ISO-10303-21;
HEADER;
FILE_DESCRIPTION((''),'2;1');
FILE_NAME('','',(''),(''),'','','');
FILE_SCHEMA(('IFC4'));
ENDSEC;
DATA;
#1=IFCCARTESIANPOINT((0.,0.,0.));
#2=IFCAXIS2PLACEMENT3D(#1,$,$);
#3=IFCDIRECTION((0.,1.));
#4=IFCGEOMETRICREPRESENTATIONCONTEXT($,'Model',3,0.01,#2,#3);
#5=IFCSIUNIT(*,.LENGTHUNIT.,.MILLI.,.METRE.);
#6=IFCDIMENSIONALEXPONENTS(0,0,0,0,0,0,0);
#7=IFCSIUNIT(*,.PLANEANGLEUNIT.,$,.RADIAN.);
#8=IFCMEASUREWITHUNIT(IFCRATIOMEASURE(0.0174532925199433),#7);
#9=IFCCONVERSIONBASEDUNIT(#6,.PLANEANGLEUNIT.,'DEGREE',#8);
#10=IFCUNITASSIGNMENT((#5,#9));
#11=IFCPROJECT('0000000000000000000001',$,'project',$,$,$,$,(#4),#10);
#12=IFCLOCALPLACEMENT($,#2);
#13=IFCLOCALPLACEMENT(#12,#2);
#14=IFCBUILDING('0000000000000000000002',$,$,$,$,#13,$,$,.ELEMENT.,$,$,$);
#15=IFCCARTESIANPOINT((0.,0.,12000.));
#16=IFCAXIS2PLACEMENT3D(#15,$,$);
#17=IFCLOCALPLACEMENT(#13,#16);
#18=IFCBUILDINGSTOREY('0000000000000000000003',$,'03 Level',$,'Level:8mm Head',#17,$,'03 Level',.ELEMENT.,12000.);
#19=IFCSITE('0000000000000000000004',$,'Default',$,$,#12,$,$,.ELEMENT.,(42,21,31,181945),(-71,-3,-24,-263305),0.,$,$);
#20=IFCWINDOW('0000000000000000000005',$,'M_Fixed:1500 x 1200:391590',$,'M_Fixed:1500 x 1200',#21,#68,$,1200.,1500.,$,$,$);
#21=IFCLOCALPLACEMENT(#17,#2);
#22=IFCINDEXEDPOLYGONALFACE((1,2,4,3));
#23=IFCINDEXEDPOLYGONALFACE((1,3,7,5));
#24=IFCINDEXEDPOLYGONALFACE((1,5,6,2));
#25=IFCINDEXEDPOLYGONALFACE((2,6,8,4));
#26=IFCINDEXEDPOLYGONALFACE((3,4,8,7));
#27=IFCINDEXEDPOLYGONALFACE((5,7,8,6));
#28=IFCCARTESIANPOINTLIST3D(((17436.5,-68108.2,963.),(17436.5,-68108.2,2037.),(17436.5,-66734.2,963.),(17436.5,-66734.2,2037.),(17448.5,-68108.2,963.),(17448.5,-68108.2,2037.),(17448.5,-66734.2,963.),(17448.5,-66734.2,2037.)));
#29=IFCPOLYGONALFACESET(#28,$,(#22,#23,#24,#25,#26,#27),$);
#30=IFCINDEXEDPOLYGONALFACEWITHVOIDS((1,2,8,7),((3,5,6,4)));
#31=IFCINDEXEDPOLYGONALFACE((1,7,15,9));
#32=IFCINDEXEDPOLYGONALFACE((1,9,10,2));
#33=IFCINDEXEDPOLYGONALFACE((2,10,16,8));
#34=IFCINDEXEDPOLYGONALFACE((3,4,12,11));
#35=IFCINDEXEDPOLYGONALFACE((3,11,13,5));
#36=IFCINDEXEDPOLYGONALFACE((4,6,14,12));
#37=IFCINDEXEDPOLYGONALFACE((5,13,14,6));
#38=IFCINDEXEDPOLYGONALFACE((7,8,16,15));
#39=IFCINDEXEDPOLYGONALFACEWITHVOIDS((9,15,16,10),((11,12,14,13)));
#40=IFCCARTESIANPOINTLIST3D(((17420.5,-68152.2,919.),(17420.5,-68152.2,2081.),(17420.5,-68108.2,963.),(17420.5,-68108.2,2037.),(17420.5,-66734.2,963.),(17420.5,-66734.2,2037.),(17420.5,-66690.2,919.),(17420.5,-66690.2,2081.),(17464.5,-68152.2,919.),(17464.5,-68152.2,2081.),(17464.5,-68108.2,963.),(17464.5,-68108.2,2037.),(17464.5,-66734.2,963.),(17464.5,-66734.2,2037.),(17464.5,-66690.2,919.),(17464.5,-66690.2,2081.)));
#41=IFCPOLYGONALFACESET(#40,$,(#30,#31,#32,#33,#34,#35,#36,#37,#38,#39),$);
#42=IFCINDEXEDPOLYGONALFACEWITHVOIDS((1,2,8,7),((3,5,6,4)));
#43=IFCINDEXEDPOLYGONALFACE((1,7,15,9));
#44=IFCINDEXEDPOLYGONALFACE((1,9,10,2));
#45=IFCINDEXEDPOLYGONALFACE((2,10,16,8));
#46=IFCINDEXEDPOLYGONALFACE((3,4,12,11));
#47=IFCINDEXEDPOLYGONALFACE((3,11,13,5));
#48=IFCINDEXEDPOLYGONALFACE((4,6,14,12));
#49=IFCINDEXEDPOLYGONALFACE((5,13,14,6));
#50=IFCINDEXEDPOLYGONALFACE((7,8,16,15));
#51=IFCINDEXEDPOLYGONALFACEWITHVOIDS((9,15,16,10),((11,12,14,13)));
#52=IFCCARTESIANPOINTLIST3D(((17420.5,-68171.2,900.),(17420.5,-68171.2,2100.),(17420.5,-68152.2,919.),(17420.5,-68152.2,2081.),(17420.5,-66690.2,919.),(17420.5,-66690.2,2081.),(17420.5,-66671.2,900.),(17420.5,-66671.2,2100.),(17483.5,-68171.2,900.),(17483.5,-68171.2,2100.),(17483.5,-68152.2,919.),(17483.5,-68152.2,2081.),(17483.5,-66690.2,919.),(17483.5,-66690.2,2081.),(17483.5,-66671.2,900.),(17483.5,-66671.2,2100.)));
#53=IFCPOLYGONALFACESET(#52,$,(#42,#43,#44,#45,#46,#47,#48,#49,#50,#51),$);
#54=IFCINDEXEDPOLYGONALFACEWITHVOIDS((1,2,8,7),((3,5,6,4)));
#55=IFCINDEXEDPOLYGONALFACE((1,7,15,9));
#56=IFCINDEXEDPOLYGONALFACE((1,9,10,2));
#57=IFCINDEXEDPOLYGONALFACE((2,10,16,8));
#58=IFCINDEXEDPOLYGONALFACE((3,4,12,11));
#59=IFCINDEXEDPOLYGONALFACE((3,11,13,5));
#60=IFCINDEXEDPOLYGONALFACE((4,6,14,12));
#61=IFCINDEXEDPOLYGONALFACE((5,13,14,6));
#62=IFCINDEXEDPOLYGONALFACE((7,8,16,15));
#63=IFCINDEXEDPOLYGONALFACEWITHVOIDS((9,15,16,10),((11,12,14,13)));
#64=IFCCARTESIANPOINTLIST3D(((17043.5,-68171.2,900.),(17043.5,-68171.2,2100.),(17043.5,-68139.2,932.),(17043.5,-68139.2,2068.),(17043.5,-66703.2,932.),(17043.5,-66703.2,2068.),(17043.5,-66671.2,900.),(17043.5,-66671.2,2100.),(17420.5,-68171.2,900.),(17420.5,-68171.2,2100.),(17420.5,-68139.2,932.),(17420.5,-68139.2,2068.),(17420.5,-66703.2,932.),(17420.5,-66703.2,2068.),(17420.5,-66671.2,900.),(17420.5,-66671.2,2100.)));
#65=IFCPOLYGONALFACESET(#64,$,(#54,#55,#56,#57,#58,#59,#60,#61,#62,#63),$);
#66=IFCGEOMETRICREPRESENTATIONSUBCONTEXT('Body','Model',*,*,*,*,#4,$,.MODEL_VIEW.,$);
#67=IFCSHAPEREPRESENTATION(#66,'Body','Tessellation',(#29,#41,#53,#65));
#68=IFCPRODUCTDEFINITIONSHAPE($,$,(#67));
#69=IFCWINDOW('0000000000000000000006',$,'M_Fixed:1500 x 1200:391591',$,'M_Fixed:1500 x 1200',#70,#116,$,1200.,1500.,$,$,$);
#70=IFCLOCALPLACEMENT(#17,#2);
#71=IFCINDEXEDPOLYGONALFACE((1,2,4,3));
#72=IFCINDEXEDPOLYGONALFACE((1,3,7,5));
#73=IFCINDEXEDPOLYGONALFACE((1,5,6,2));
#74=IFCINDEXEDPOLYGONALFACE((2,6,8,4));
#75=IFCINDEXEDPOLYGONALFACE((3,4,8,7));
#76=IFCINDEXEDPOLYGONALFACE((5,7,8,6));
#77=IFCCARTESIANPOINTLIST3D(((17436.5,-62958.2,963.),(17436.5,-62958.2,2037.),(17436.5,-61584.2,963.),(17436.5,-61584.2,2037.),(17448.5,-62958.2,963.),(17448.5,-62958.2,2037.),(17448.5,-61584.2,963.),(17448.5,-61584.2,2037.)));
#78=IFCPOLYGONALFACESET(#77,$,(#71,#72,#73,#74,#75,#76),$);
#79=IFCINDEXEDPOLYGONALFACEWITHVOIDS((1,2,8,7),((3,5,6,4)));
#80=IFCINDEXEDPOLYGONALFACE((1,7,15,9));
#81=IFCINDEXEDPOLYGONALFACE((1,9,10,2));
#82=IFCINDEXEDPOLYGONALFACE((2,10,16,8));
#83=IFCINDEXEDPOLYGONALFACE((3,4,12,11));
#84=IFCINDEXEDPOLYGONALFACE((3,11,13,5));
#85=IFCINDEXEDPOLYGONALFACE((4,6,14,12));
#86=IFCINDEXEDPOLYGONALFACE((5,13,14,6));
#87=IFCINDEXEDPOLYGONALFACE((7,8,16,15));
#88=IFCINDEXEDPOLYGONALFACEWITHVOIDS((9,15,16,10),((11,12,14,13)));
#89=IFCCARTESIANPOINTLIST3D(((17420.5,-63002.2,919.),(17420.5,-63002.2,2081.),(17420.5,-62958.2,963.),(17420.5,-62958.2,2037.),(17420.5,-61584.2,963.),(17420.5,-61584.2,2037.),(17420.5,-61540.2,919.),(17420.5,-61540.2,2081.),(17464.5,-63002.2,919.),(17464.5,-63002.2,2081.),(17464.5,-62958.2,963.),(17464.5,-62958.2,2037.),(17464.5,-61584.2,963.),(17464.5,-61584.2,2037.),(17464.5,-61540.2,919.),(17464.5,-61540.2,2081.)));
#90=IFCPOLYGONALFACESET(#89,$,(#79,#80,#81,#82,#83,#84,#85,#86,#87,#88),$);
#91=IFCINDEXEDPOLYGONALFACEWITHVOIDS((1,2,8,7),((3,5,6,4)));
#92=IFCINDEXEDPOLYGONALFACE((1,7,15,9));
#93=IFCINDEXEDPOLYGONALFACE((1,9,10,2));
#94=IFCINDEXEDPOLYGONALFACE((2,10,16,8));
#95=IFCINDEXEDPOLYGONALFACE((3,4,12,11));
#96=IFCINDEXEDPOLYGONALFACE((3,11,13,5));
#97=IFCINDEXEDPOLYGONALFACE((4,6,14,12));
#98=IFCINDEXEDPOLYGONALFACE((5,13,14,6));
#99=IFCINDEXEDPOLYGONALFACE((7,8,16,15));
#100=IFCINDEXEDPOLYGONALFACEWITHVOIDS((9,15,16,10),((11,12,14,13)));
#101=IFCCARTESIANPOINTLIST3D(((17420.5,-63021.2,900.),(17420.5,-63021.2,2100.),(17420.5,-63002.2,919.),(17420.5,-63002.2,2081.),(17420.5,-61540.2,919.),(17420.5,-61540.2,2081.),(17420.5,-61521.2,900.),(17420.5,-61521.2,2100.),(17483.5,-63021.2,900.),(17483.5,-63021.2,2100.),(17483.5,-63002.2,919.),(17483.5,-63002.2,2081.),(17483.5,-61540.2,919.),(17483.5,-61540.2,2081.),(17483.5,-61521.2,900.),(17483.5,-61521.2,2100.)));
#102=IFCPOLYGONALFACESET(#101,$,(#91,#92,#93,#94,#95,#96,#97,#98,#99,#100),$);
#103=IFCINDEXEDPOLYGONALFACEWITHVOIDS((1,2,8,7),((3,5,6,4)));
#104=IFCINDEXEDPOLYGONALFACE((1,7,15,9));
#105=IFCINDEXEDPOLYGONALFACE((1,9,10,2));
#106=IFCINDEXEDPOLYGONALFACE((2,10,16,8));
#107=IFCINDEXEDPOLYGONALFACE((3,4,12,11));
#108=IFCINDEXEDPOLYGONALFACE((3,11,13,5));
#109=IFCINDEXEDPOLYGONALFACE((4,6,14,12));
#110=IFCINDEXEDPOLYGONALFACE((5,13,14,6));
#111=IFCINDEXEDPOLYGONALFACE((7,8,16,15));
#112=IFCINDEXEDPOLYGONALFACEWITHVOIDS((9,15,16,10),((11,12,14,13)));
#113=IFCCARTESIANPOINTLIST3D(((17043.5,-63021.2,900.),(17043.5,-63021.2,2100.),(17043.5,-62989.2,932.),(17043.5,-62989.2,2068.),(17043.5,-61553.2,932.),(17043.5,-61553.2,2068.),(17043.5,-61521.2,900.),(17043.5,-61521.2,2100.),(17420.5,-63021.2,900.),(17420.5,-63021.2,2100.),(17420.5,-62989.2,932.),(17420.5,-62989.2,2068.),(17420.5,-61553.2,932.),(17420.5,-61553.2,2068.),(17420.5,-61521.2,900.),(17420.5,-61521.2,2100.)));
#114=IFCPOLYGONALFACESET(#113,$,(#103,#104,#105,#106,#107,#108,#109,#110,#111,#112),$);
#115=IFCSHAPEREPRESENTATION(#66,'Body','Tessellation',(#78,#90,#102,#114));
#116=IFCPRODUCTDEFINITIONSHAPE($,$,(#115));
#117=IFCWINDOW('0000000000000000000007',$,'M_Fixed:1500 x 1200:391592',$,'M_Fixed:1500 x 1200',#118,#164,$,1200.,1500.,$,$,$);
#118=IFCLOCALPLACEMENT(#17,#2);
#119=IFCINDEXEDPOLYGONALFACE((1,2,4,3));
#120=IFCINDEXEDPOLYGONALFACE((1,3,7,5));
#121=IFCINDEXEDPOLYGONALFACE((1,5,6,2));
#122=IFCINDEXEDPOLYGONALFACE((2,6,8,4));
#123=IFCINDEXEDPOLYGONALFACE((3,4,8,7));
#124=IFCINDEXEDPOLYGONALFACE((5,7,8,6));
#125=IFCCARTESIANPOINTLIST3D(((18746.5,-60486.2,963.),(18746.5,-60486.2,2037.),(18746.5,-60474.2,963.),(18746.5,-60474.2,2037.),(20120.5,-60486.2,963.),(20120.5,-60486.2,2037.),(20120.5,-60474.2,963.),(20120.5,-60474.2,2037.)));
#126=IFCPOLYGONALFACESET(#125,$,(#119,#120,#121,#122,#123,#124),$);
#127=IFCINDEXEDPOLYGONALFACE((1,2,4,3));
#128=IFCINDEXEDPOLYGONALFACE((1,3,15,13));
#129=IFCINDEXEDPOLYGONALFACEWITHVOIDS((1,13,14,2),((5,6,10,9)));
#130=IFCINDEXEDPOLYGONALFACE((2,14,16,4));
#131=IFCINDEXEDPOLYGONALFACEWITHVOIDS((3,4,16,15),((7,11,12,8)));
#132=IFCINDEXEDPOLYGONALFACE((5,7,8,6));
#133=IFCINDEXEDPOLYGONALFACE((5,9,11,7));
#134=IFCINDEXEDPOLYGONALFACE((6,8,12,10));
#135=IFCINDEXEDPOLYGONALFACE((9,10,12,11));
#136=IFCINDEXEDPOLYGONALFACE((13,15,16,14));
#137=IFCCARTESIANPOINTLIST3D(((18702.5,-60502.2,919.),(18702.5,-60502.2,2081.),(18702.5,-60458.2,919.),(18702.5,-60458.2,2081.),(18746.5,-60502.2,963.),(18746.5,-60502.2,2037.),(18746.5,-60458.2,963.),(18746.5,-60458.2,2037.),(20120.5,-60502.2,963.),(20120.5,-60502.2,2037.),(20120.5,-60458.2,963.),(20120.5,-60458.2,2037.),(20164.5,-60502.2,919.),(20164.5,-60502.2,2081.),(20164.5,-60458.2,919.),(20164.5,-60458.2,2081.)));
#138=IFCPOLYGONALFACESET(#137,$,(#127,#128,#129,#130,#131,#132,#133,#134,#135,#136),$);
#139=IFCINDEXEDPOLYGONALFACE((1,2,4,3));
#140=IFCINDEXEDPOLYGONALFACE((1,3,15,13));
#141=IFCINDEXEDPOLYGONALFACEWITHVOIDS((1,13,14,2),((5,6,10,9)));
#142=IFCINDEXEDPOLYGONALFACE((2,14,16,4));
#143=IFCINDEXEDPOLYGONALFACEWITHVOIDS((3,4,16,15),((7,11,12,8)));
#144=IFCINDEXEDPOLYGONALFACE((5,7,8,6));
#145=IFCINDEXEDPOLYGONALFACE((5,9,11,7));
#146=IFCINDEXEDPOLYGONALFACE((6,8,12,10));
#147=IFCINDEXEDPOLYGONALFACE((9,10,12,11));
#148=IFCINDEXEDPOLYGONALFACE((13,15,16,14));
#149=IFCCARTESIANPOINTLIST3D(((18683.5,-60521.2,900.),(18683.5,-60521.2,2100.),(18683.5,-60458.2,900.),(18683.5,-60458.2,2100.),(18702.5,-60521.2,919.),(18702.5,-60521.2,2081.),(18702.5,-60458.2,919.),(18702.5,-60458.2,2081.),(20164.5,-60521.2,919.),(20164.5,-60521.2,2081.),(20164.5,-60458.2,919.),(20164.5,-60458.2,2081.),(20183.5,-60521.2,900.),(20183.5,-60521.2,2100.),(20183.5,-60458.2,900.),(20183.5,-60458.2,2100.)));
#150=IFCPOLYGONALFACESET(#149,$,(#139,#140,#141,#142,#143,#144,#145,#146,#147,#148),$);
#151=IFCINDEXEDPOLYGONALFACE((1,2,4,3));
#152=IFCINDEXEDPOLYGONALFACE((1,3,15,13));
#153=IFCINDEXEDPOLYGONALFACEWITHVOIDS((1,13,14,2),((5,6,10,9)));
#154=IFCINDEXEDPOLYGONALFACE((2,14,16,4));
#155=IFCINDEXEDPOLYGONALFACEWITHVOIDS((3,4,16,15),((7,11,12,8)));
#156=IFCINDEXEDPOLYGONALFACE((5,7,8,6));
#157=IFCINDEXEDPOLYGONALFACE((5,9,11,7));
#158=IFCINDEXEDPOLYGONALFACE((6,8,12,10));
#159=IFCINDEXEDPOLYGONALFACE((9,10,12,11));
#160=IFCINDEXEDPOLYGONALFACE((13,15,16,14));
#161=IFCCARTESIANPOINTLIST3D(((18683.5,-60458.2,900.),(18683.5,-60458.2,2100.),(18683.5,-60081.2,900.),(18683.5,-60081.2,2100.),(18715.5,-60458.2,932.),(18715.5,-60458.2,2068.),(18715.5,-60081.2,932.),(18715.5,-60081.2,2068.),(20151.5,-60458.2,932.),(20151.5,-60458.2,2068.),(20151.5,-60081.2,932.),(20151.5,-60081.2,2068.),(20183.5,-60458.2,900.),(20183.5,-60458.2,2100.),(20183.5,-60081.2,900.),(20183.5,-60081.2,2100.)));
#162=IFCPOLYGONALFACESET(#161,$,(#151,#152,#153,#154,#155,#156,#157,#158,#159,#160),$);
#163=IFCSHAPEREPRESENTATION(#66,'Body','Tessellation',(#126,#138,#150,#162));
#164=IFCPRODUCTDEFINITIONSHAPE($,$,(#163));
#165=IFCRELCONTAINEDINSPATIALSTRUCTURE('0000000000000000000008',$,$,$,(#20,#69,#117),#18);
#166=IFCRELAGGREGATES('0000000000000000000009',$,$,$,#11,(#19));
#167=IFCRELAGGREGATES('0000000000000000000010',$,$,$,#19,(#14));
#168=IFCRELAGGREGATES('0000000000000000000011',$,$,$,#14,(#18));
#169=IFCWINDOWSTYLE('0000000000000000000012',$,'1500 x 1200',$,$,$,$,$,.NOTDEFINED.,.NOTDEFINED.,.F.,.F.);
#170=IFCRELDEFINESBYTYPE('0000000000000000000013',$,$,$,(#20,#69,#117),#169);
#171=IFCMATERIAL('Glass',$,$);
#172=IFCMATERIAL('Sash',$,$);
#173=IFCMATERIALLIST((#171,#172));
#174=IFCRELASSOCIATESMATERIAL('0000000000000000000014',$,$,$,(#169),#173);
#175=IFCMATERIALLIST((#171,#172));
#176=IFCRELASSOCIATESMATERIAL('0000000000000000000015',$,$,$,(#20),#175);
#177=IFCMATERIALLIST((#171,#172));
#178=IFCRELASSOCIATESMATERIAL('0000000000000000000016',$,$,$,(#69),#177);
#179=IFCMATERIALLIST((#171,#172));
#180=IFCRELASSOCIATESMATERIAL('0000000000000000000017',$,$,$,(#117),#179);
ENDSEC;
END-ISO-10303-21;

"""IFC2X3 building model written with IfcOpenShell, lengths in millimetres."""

from ifc_helpers import new_model, entity, si_unit, converted_unit, direction, frame, origin, origin_2d_with_axis, place, context, subcontext, project, spatial, polyline, rectangle, outline, extrude, source, transform, mapped, material, material_list, type_object, type_shapes, element, save


model = new_model("IFC2X3")

# Units and contexts
model_context = context("Model", 3, precision=0.01, world=origin(), true_north=direction((0.0, 1.0)))
body_context = subcontext(model_context, "Body", "Model", "MODEL_VIEW")
ifc_project = project(units=[si_unit("LENGTHUNIT", "METRE", prefix="MILLI"), converted_unit("PLANEANGLEUNIT", "DEGREE", entity("IfcRatioMeasure", 0.0174532925199433), si_unit("PLANEANGLEUNIT", "RADIAN"), dimensions=[0, 0, 0, 0, 0, 0, 0])], contexts=[model_context])

# Site, building, storey
site_placement = place(None, origin())
site = spatial("IfcSite", under=ifc_project, at=site_placement, Name="Default", CompositionType="ELEMENT", RefLatitude=(42, 21, 31, 181945), RefLongitude=(-71, -3, -24, -263305), RefElevation=0.0)
building_placement = place(site_placement, origin())
building = spatial("IfcBuilding", under=site, at=building_placement, CompositionType="ELEMENT")
storey_placement = place(building_placement, frame((0.0, 0.0, 12000.0)))
storey = spatial("IfcBuildingStorey", under=building, at=storey_placement, Name="03 Level", ObjectType="Level:8mm Head", LongName="03 Level", CompositionType="ELEMENT", Elevation=12000.0)

# Windows
ifc_material_1 = material(Name="Glass")
ifc_material_2 = material(Name="Sash")
ifc_material_list_1 = material_list([ifc_material_1, ifc_material_2])
ifc_material_list_2 = material_list([ifc_material_1, ifc_material_2])
window_style_1 = type_object("IfcWindowStyle", Name="1500 x 1200", ConstructionType="NOTDEFINED", OperationType="NOTDEFINED", ParameterTakesPrecedence=False, Sizeable=False, material=ifc_material_list_2)
shared_shape_1 = source(origin(), body_context, "Body", "SweptSolid", [
    extrude(rectangle(XDim=1374.0, YDim=12.0, at=origin_2d_with_axis()), frame((750.0, 425.0, 63.0), z_axis=(0.0, 0.0, 1.0), x_axis=(-1.0, 0.0, 0.0)), (0.0, 0.0, 1.0), 1074.0),
    extrude(outline(polyline([(-731.0, -581.0), (731.0, -581.0), (731.0, 581.0), (-731.0, 581.0), (-731.0, -581.0)]), holes=[polyline([(-687.0, -537.0), (-687.0, 537.0), (687.0, 537.0), (687.0, -537.0), (-687.0, -537.0)])]), frame((750.0, 447.0, 600.0), z_axis=(0.0, -1.0, 0.0), x_axis=(-1.0, 0.0, 0.0)), (0.0, 0.0, 1.0), 44.0),
    extrude(outline(polyline([(-750.0, -600.0), (750.0, -600.0), (750.0, 600.0), (-750.0, 600.0), (-750.0, -600.0)]), holes=[polyline([(-731.0, -581.0), (-731.0, 581.0), (731.0, 581.0), (731.0, -581.0), (-731.0, -581.0)])]), frame((750.0, 466.0, 600.0), z_axis=(0.0, -1.0, 0.0), x_axis=(-1.0, 0.0, 0.0)), (0.0, 0.0, 1.0), 63.0),
    extrude(outline(polyline([(-750.0, -600.0), (750.0, -600.0), (750.0, 600.0), (-750.0, 600.0), (-750.0, -600.0)]), holes=[polyline([(-718.0, -568.0), (-718.0, 568.0), (718.0, 568.0), (718.0, -568.0), (-718.0, -568.0)])]), frame((750.0, 403.0, 600.0), z_axis=(0.0, -1.0, 0.0), x_axis=(-1.0, 0.0, 0.0)), (0.0, 0.0, 1.0), 377.0),
])
type_shapes(window_style_1, [shared_shape_1])
window_1_placement = place(storey_placement, frame((17017.5, -66671.2, 900.0), z_axis=(0.0, 0.0, 1.0), x_axis=(0.0, -1.0, 0.0)))
element("IfcWindow", 1, at=window_1_placement, inside=storey, type_object=window_style_1, material=ifc_material_list_1, Name="M_Fixed:1500 x 1200:391590", ObjectType="M_Fixed:1500 x 1200", OverallHeight=1200.0, OverallWidth=1500.0, context=body_context, shape_type="MappedRepresentation", body=[
    mapped(shared_shape_1, transform((0.0, 0.0, 0.0), scale=1.0)),
])
ifc_material_list_3 = material_list([ifc_material_1, ifc_material_2])
window_2_placement = place(storey_placement, frame((17017.5, -61521.2, 900.0), z_axis=(0.0, 0.0, 1.0), x_axis=(0.0, -1.0, 0.0)))
element("IfcWindow", 2, at=window_2_placement, inside=storey, type_object=window_style_1, material=ifc_material_list_3, Name="M_Fixed:1500 x 1200:391591", ObjectType="M_Fixed:1500 x 1200", OverallHeight=1200.0, OverallWidth=1500.0, context=body_context, shape_type="MappedRepresentation", body=[
    mapped(shared_shape_1, transform((0.0, 0.0, 0.0), scale=1.0)),
])
ifc_material_list_4 = material_list([ifc_material_1, ifc_material_2])
window_3_placement = place(storey_placement, frame((20183.5, -60055.2, 900.0), z_axis=(0.0, 0.0, 1.0), x_axis=(-1.0, 0.0, 0.0)))
element("IfcWindow", 3, at=window_3_placement, inside=storey, type_object=window_style_1, material=ifc_material_list_4, Name="M_Fixed:1500 x 1200:391592", ObjectType="M_Fixed:1500 x 1200", OverallHeight=1200.0, OverallWidth=1500.0, context=body_context, shape_type="MappedRepresentation", body=[
    mapped(shared_shape_1, transform((0.0, 0.0, 0.0), scale=1.0)),
])

save(model, "model.ifc")
